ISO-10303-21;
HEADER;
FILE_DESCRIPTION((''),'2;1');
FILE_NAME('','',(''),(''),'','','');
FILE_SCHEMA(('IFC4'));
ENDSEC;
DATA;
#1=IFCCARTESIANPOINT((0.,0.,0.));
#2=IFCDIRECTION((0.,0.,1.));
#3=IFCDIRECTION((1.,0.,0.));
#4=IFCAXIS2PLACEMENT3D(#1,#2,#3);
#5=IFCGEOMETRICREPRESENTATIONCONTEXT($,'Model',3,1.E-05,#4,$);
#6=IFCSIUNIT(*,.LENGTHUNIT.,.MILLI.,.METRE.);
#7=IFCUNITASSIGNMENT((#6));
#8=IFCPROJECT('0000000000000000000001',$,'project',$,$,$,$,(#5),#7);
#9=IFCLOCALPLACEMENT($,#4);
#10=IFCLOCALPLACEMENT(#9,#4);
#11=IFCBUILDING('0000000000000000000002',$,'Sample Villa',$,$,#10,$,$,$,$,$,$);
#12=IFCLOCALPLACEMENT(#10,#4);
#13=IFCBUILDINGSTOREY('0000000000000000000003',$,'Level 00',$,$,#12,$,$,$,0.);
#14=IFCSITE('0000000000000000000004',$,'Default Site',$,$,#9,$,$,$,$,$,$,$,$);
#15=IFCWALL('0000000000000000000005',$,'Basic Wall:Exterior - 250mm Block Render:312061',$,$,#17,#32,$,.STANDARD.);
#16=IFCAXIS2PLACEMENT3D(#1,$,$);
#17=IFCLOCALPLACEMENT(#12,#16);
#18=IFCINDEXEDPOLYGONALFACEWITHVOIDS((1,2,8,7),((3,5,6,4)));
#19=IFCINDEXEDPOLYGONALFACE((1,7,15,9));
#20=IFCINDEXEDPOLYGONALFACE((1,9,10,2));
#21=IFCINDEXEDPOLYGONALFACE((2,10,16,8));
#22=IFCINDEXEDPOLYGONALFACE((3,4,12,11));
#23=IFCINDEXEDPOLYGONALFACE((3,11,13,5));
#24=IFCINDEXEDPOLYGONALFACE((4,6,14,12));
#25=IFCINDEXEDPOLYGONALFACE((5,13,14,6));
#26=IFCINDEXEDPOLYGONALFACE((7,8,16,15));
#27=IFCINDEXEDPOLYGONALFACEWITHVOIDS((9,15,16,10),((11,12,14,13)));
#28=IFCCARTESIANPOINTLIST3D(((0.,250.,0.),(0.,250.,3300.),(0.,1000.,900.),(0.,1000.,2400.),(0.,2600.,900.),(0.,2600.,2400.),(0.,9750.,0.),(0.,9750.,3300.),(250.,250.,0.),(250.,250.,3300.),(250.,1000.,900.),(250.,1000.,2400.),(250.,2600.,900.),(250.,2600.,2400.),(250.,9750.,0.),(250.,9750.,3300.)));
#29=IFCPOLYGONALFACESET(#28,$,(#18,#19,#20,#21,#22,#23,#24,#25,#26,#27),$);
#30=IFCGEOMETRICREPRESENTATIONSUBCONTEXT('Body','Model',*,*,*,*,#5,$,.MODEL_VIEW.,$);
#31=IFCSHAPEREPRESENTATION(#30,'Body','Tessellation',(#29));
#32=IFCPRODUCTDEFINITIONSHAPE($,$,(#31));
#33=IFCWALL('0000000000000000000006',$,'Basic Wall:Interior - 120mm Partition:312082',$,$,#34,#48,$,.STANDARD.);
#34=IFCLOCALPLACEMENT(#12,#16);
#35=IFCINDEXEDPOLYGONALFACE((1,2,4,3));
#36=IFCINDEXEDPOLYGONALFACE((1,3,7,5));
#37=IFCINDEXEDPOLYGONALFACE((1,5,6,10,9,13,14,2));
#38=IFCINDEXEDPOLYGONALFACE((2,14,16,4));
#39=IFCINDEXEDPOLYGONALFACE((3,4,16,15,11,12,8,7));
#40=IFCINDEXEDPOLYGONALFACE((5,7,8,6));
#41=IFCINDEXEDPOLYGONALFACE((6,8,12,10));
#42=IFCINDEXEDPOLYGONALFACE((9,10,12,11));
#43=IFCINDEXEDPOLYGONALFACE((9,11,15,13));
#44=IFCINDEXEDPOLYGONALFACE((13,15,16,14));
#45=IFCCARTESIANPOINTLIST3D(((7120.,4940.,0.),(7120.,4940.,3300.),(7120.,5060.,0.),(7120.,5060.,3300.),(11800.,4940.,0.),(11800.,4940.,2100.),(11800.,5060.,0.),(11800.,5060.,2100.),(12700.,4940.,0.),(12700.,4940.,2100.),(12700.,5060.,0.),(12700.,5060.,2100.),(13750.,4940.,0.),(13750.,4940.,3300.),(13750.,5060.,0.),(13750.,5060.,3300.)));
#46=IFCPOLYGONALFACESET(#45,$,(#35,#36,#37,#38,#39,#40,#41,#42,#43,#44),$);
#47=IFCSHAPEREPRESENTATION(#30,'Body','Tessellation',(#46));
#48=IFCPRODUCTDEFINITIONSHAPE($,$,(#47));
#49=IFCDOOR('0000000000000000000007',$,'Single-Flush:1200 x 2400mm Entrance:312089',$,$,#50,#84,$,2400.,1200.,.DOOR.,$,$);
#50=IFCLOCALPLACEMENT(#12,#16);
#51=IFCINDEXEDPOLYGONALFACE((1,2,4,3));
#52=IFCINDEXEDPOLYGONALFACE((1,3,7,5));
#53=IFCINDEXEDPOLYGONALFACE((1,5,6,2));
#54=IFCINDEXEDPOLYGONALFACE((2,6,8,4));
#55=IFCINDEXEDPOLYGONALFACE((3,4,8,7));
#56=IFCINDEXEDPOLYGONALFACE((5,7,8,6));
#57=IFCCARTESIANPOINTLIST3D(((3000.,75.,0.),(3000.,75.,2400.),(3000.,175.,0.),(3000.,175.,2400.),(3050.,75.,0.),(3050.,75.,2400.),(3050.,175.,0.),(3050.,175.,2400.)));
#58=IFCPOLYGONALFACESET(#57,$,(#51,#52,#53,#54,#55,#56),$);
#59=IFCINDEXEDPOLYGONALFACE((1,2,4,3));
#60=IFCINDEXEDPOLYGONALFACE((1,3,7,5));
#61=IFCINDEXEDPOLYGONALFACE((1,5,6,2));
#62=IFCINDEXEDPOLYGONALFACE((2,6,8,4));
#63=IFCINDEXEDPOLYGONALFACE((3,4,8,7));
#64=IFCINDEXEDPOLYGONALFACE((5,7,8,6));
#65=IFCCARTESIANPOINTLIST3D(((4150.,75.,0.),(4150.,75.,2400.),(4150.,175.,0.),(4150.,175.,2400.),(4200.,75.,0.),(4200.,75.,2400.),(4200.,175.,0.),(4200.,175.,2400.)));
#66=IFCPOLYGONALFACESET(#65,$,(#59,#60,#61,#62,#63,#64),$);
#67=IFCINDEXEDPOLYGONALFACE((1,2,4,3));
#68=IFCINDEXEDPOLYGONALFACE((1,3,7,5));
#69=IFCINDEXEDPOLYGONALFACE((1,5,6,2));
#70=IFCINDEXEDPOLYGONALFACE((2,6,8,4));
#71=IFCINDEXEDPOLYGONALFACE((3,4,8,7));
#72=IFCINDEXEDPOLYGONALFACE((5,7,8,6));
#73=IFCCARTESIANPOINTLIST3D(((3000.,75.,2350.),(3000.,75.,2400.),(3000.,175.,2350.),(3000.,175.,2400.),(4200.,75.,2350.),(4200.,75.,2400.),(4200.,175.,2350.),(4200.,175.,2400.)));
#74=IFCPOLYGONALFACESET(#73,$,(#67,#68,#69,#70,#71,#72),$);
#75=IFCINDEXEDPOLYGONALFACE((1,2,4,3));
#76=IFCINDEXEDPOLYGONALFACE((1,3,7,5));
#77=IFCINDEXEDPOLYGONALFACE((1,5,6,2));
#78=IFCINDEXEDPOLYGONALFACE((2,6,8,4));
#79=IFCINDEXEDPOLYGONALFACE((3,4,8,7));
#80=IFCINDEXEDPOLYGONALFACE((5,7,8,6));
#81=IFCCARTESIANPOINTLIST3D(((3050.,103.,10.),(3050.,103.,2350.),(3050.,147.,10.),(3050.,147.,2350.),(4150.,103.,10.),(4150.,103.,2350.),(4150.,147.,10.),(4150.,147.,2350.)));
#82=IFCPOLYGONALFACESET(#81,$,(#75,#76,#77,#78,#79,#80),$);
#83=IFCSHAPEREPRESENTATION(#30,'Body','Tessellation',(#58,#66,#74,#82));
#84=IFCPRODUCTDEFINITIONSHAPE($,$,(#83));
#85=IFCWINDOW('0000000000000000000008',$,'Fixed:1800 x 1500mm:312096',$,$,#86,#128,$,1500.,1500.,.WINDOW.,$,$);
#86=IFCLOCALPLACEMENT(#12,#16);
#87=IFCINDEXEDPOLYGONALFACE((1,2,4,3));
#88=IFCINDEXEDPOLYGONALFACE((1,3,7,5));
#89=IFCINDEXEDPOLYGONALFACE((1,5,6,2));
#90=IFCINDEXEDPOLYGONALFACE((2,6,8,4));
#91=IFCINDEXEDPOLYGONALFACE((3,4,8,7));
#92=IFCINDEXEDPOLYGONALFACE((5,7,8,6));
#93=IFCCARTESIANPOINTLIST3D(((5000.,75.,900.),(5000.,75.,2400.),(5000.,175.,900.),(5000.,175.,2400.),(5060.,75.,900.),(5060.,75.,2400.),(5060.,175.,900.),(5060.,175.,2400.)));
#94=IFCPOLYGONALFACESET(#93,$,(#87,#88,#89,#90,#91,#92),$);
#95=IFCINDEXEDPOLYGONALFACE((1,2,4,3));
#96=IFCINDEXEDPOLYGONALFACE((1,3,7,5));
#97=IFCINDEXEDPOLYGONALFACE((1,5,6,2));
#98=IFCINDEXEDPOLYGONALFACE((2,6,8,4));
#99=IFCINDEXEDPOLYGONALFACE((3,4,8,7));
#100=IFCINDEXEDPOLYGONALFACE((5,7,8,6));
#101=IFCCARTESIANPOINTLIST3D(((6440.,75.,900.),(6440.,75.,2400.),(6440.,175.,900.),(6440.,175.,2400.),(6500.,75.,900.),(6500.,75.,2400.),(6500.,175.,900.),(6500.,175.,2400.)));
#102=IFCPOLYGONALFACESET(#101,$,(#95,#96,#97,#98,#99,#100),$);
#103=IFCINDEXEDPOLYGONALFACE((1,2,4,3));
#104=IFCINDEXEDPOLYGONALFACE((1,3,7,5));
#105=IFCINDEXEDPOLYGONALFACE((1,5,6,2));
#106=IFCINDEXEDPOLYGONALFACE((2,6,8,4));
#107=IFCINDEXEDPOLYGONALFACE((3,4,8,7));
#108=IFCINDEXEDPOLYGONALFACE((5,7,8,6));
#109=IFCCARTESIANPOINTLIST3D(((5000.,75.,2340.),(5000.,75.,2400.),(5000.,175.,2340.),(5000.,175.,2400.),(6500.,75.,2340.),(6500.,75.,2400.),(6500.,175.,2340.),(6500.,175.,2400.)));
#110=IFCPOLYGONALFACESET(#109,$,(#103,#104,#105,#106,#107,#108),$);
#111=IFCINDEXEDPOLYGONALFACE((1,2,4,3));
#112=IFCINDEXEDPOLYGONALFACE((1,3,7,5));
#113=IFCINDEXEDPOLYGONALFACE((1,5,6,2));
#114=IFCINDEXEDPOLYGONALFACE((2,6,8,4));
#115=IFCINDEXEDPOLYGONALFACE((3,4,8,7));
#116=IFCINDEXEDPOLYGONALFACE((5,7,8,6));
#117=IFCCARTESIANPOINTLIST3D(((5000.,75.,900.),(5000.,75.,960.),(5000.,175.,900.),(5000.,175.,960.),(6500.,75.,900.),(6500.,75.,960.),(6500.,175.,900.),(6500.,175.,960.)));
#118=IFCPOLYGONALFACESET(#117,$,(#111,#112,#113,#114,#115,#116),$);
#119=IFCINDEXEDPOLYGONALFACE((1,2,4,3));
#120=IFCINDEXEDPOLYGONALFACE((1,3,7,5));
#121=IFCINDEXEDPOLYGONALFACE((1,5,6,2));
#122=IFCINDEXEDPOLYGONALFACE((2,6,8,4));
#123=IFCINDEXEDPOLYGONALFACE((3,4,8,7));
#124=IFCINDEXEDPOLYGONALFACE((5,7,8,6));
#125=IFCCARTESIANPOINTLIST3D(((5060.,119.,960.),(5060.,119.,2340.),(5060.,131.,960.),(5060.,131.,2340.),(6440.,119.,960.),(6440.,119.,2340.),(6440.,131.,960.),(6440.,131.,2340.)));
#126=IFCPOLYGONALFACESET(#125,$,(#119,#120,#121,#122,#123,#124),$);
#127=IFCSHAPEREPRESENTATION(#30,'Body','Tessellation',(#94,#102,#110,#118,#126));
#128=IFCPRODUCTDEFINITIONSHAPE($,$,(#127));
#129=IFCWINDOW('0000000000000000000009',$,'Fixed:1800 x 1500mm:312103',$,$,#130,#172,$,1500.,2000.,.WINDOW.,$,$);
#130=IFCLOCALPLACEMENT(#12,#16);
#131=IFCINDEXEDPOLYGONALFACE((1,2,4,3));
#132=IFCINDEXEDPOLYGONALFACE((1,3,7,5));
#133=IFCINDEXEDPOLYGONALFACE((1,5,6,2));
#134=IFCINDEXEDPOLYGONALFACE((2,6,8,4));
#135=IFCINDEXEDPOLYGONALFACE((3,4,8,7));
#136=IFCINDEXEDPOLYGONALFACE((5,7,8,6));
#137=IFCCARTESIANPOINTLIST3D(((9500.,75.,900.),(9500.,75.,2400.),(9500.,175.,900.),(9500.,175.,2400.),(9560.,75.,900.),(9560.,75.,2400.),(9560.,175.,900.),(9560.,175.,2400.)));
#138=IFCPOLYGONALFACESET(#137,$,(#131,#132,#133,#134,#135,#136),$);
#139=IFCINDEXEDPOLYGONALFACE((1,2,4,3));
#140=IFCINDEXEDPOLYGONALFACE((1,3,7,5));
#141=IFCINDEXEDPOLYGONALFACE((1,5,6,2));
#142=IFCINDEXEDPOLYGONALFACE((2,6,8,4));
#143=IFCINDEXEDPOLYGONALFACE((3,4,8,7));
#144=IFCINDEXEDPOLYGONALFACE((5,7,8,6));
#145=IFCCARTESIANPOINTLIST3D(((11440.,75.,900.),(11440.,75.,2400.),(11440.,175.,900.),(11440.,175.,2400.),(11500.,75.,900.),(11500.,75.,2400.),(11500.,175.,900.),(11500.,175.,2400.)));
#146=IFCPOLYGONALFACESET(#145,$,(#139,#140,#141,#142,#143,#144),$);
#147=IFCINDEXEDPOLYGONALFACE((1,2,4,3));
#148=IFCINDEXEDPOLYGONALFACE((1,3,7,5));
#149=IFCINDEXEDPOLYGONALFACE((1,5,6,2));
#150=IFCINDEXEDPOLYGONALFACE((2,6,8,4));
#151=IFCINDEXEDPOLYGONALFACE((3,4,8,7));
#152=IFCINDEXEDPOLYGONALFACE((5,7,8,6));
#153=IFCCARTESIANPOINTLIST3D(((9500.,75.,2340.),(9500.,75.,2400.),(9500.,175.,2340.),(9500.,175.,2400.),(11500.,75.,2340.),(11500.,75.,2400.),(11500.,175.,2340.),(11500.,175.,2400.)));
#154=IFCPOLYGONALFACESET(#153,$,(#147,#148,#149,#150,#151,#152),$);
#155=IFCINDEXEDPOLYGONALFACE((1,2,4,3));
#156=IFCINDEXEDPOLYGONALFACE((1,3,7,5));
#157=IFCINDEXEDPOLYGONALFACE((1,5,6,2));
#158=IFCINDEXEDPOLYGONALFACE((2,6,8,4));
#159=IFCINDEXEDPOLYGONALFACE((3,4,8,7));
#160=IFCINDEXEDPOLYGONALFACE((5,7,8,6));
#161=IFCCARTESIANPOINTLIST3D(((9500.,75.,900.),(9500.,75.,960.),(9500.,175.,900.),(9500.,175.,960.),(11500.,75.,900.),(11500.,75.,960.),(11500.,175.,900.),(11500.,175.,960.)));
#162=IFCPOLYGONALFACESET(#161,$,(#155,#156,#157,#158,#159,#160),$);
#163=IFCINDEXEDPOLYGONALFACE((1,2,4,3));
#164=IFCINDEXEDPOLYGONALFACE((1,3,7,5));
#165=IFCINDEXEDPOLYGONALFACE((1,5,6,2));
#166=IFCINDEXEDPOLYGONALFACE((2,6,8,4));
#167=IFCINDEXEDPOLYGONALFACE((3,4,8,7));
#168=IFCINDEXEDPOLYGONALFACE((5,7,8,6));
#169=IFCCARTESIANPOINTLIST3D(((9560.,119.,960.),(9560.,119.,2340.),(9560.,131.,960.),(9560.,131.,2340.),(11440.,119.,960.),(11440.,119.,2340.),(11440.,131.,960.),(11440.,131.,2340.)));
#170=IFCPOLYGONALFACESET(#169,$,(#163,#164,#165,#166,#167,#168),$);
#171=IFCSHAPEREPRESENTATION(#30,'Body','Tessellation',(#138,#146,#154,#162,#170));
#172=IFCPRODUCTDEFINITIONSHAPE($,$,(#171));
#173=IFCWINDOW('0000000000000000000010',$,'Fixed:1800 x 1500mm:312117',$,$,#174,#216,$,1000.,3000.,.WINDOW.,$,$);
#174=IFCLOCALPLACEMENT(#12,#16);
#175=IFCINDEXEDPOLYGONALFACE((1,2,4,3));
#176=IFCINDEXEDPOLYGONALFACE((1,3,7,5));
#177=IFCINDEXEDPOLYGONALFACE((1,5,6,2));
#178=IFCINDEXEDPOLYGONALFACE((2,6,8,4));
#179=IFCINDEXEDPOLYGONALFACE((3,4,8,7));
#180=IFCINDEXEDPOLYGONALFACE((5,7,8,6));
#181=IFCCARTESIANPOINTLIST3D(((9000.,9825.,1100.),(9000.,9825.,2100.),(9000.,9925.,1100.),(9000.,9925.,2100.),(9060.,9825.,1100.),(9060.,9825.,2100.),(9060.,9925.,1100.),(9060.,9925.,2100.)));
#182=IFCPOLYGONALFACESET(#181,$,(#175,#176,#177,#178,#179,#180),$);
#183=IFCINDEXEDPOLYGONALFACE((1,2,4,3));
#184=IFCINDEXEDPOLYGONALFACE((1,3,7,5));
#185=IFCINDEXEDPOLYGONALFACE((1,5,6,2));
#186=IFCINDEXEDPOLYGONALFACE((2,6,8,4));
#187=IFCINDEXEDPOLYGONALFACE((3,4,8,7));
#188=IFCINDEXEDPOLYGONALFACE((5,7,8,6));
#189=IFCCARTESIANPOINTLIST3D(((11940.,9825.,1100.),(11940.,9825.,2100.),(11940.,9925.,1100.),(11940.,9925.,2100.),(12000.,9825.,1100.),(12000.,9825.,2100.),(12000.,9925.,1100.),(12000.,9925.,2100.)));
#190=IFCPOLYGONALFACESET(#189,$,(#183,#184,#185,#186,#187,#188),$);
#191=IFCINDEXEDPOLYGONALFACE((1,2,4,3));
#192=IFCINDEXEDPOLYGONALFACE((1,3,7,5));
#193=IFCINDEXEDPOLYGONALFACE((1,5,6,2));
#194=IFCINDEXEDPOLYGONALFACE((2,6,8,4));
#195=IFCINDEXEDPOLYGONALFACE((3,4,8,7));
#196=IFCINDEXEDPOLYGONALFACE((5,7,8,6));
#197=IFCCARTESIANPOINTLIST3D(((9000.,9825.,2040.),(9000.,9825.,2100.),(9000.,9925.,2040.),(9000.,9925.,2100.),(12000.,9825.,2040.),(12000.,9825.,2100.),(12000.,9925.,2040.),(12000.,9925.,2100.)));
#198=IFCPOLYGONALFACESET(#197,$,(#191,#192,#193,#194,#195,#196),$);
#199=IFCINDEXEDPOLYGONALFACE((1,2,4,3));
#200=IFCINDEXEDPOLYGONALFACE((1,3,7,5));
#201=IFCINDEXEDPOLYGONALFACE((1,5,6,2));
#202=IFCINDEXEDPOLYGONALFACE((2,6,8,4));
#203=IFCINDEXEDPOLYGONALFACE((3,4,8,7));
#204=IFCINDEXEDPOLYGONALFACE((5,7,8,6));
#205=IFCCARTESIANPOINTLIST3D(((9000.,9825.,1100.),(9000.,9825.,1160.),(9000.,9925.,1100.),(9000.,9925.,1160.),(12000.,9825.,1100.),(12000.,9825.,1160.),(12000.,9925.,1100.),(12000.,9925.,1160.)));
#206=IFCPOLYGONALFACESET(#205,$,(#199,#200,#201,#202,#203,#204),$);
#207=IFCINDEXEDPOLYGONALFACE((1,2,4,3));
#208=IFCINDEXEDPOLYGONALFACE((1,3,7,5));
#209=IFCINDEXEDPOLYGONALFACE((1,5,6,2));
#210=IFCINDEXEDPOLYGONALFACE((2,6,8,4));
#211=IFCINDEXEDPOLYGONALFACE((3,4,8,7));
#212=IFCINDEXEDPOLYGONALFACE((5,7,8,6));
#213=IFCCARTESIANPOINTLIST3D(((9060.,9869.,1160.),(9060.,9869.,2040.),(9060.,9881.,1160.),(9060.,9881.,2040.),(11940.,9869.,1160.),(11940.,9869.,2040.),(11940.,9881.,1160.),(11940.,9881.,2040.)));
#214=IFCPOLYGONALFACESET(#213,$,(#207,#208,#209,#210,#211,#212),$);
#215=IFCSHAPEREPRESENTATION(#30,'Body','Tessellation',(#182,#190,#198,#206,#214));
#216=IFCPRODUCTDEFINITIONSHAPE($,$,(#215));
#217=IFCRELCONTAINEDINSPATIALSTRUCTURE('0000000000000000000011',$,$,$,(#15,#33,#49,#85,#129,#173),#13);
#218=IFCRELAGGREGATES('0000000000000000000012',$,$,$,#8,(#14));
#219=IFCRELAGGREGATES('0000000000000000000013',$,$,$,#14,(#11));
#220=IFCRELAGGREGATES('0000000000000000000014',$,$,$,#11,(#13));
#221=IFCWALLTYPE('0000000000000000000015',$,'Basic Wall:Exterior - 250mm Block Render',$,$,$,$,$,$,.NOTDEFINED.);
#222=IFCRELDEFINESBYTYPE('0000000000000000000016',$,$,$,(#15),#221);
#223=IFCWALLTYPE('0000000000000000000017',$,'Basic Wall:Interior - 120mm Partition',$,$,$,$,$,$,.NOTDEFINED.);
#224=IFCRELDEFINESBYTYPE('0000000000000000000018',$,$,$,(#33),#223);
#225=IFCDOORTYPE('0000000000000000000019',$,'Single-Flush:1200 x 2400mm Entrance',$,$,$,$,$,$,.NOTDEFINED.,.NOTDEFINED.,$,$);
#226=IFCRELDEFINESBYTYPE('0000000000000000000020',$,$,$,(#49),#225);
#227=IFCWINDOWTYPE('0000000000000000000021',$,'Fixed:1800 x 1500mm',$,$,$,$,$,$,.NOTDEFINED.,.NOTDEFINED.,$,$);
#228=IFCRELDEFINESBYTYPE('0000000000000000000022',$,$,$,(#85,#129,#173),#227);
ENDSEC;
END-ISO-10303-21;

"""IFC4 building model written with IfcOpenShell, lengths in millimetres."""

from ifc_helpers import new_model, si_unit, frame, frame_2d, origin_with_axes, place, context, subcontext, project, spatial, rectangle, extrude, type_object, element, save


model = new_model("IFC4")

# Units and contexts
model_context = context("Model", 3, precision=1e-05, world=origin_with_axes())
body_context = subcontext(model_context, "Body", "Model", "MODEL_VIEW")
ifc_project = project(units=[si_unit("LENGTHUNIT", "METRE", prefix="MILLI")], contexts=[model_context])

# Site, building, storey
site_placement = place(None, origin_with_axes())
site = spatial("IfcSite", under=ifc_project, at=site_placement, Name="Default Site")
building_placement = place(site_placement, origin_with_axes())
building = spatial("IfcBuilding", under=site, at=building_placement, Name="Sample Villa")
storey_placement = place(building_placement, origin_with_axes())
storey = spatial("IfcBuildingStorey", under=building, at=storey_placement, Name="Level 00", Elevation=0.0)

# Shared definitions
wall_type_1 = type_object("IfcWallType", Name="Basic Wall:Exterior - 250mm Block Render", PredefinedType="NOTDEFINED")

# Wall, opening
wall_1_placement = place(storey_placement, origin_with_axes())
wall_1 = element("IfcWall", 1, at=wall_1_placement, inside=storey, type_object=wall_type_1, Name="Basic Wall:Exterior - 250mm Block Render:312061", PredefinedType="STANDARD", context=body_context, shape_type="SweptSolid", body=[
    extrude(rectangle(XDim=250.0, YDim=9500.0, at=frame_2d((125.0, 4750.0))), frame((0.0, 250.0, 0.0)), (0.0, 0.0, 1.0), 3300.0),
])
opening_1_placement = place(wall_1_placement, origin_with_axes())
element("IfcOpeningElement", 2, at=opening_1_placement, cuts=wall_1, context=body_context, shape_type="SweptSolid", body=[
    extrude(rectangle(XDim=350.0, YDim=1600.0, at=frame_2d((175.0, 800.0))), frame((-50.0, 1000.0, 900.0)), (0.0, 0.0, 1.0), 1500.0),
])

# Shared definitions
wall_type_2 = type_object("IfcWallType", Name="Basic Wall:Interior - 120mm Partition", PredefinedType="NOTDEFINED")

# Wall, opening
wall_2_placement = place(storey_placement, origin_with_axes())
wall_2 = element("IfcWall", 3, at=wall_2_placement, inside=storey, type_object=wall_type_2, Name="Basic Wall:Interior - 120mm Partition:312082", PredefinedType="STANDARD", context=body_context, shape_type="SweptSolid", body=[
    extrude(rectangle(XDim=6630.0, YDim=120.0, at=frame_2d((3315.0, 60.0))), frame((7120.0, 4940.0, 0.0)), (0.0, 0.0, 1.0), 3300.0),
])
opening_2_placement = place(wall_2_placement, origin_with_axes())
element("IfcOpeningElement", 4, at=opening_2_placement, cuts=wall_2, context=body_context, shape_type="SweptSolid", body=[
    extrude(rectangle(XDim=900.0, YDim=220.0, at=frame_2d((450.0, 110.0))), frame((11800.0, 4890.0, 0.0)), (0.0, 0.0, 1.0), 2100.0),
])

# Door
door_type_1 = type_object("IfcDoorType", Name="Single-Flush:1200 x 2400mm Entrance", OperationType="NOTDEFINED", PredefinedType="NOTDEFINED")
door_1_placement = place(storey_placement, origin_with_axes())
element("IfcDoor", 5, at=door_1_placement, inside=storey, type_object=door_type_1, Name="Single-Flush:1200 x 2400mm Entrance:312089", OverallHeight=2400.0, OverallWidth=1200.0, PredefinedType="DOOR", context=body_context, shape_type="SweptSolid", body=[
    extrude(rectangle(XDim=50.0, YDim=100.0, at=frame_2d((25.0, 50.0))), frame((3000.0, 75.0, 0.0)), (0.0, 0.0, 1.0), 2400.0),
    extrude(rectangle(XDim=50.0, YDim=100.0, at=frame_2d((25.0, 50.0))), frame((4150.0, 75.0, 0.0)), (0.0, 0.0, 1.0), 2400.0),
    extrude(rectangle(XDim=1200.0, YDim=100.0, at=frame_2d((600.0, 50.0))), frame((3000.0, 75.0, 2350.0)), (0.0, 0.0, 1.0), 50.0),
    extrude(rectangle(XDim=1100.0, YDim=44.0, at=frame_2d((550.0, 22.0))), frame((3050.0, 103.0, 10.0)), (0.0, 0.0, 1.0), 2340.0),
])

# Windows
window_type = type_object("IfcWindowType", Name="Fixed:1800 x 1500mm", PartitioningType="NOTDEFINED", PredefinedType="NOTDEFINED")
window_1_placement = place(storey_placement, origin_with_axes())
element("IfcWindow", 6, at=window_1_placement, inside=storey, type_object=window_type, Name="Fixed:1800 x 1500mm:312096", OverallHeight=1500.0, OverallWidth=1500.0, PredefinedType="WINDOW", context=body_context, shape_type="SweptSolid", body=[
    extrude(rectangle(XDim=60.0, YDim=100.0, at=frame_2d((30.0, 50.0))), frame((5000.0, 75.0, 900.0)), (0.0, 0.0, 1.0), 1500.0),
    extrude(rectangle(XDim=60.0, YDim=100.0, at=frame_2d((30.0, 50.0))), frame((6440.0, 75.0, 900.0)), (0.0, 0.0, 1.0), 1500.0),
    extrude(rectangle(XDim=1500.0, YDim=100.0, at=frame_2d((750.0, 50.0))), frame((5000.0, 75.0, 2340.0)), (0.0, 0.0, 1.0), 60.0),
    extrude(rectangle(XDim=1500.0, YDim=100.0, at=frame_2d((750.0, 50.0))), frame((5000.0, 75.0, 900.0)), (0.0, 0.0, 1.0), 60.0),
    extrude(rectangle(XDim=1380.0, YDim=12.0, at=frame_2d((690.0, 6.0))), frame((5060.0, 119.0, 960.0)), (0.0, 0.0, 1.0), 1380.0),
])
window_2_placement = place(storey_placement, origin_with_axes())
element("IfcWindow", 7, at=window_2_placement, inside=storey, type_object=window_type, Name="Fixed:1800 x 1500mm:312103", OverallHeight=1500.0, OverallWidth=2000.0, PredefinedType="WINDOW", context=body_context, shape_type="SweptSolid", body=[
    extrude(rectangle(XDim=60.0, YDim=100.0, at=frame_2d((30.0, 50.0))), frame((9500.0, 75.0, 900.0)), (0.0, 0.0, 1.0), 1500.0),
    extrude(rectangle(XDim=60.0, YDim=100.0, at=frame_2d((30.0, 50.0))), frame((11440.0, 75.0, 900.0)), (0.0, 0.0, 1.0), 1500.0),
    extrude(rectangle(XDim=2000.0, YDim=100.0, at=frame_2d((1000.0, 50.0))), frame((9500.0, 75.0, 2340.0)), (0.0, 0.0, 1.0), 60.0),
    extrude(rectangle(XDim=2000.0, YDim=100.0, at=frame_2d((1000.0, 50.0))), frame((9500.0, 75.0, 900.0)), (0.0, 0.0, 1.0), 60.0),
    extrude(rectangle(XDim=1880.0, YDim=12.0, at=frame_2d((940.0, 6.0))), frame((9560.0, 119.0, 960.0)), (0.0, 0.0, 1.0), 1380.0),
])
window_3_placement = place(storey_placement, origin_with_axes())
element("IfcWindow", 8, at=window_3_placement, inside=storey, type_object=window_type, Name="Fixed:1800 x 1500mm:312117", OverallHeight=1000.0, OverallWidth=3000.0, PredefinedType="WINDOW", context=body_context, shape_type="SweptSolid", body=[
    extrude(rectangle(XDim=60.0, YDim=100.0, at=frame_2d((30.0, 50.0))), frame((9000.0, 9825.0, 1100.0)), (0.0, 0.0, 1.0), 1000.0),
    extrude(rectangle(XDim=60.0, YDim=100.0, at=frame_2d((30.0, 50.0))), frame((11940.0, 9825.0, 1100.0)), (0.0, 0.0, 1.0), 1000.0),
    extrude(rectangle(XDim=3000.0, YDim=100.0, at=frame_2d((1500.0, 50.0))), frame((9000.0, 9825.0, 2040.0)), (0.0, 0.0, 1.0), 60.0),
    extrude(rectangle(XDim=3000.0, YDim=100.0, at=frame_2d((1500.0, 50.0))), frame((9000.0, 9825.0, 1100.0)), (0.0, 0.0, 1.0), 60.0),
    extrude(rectangle(XDim=2880.0, YDim=12.0, at=frame_2d((1440.0, 6.0))), frame((9060.0, 9869.0, 1160.0)), (0.0, 0.0, 1.0), 880.0),
])

save(model, "model.ifc")
